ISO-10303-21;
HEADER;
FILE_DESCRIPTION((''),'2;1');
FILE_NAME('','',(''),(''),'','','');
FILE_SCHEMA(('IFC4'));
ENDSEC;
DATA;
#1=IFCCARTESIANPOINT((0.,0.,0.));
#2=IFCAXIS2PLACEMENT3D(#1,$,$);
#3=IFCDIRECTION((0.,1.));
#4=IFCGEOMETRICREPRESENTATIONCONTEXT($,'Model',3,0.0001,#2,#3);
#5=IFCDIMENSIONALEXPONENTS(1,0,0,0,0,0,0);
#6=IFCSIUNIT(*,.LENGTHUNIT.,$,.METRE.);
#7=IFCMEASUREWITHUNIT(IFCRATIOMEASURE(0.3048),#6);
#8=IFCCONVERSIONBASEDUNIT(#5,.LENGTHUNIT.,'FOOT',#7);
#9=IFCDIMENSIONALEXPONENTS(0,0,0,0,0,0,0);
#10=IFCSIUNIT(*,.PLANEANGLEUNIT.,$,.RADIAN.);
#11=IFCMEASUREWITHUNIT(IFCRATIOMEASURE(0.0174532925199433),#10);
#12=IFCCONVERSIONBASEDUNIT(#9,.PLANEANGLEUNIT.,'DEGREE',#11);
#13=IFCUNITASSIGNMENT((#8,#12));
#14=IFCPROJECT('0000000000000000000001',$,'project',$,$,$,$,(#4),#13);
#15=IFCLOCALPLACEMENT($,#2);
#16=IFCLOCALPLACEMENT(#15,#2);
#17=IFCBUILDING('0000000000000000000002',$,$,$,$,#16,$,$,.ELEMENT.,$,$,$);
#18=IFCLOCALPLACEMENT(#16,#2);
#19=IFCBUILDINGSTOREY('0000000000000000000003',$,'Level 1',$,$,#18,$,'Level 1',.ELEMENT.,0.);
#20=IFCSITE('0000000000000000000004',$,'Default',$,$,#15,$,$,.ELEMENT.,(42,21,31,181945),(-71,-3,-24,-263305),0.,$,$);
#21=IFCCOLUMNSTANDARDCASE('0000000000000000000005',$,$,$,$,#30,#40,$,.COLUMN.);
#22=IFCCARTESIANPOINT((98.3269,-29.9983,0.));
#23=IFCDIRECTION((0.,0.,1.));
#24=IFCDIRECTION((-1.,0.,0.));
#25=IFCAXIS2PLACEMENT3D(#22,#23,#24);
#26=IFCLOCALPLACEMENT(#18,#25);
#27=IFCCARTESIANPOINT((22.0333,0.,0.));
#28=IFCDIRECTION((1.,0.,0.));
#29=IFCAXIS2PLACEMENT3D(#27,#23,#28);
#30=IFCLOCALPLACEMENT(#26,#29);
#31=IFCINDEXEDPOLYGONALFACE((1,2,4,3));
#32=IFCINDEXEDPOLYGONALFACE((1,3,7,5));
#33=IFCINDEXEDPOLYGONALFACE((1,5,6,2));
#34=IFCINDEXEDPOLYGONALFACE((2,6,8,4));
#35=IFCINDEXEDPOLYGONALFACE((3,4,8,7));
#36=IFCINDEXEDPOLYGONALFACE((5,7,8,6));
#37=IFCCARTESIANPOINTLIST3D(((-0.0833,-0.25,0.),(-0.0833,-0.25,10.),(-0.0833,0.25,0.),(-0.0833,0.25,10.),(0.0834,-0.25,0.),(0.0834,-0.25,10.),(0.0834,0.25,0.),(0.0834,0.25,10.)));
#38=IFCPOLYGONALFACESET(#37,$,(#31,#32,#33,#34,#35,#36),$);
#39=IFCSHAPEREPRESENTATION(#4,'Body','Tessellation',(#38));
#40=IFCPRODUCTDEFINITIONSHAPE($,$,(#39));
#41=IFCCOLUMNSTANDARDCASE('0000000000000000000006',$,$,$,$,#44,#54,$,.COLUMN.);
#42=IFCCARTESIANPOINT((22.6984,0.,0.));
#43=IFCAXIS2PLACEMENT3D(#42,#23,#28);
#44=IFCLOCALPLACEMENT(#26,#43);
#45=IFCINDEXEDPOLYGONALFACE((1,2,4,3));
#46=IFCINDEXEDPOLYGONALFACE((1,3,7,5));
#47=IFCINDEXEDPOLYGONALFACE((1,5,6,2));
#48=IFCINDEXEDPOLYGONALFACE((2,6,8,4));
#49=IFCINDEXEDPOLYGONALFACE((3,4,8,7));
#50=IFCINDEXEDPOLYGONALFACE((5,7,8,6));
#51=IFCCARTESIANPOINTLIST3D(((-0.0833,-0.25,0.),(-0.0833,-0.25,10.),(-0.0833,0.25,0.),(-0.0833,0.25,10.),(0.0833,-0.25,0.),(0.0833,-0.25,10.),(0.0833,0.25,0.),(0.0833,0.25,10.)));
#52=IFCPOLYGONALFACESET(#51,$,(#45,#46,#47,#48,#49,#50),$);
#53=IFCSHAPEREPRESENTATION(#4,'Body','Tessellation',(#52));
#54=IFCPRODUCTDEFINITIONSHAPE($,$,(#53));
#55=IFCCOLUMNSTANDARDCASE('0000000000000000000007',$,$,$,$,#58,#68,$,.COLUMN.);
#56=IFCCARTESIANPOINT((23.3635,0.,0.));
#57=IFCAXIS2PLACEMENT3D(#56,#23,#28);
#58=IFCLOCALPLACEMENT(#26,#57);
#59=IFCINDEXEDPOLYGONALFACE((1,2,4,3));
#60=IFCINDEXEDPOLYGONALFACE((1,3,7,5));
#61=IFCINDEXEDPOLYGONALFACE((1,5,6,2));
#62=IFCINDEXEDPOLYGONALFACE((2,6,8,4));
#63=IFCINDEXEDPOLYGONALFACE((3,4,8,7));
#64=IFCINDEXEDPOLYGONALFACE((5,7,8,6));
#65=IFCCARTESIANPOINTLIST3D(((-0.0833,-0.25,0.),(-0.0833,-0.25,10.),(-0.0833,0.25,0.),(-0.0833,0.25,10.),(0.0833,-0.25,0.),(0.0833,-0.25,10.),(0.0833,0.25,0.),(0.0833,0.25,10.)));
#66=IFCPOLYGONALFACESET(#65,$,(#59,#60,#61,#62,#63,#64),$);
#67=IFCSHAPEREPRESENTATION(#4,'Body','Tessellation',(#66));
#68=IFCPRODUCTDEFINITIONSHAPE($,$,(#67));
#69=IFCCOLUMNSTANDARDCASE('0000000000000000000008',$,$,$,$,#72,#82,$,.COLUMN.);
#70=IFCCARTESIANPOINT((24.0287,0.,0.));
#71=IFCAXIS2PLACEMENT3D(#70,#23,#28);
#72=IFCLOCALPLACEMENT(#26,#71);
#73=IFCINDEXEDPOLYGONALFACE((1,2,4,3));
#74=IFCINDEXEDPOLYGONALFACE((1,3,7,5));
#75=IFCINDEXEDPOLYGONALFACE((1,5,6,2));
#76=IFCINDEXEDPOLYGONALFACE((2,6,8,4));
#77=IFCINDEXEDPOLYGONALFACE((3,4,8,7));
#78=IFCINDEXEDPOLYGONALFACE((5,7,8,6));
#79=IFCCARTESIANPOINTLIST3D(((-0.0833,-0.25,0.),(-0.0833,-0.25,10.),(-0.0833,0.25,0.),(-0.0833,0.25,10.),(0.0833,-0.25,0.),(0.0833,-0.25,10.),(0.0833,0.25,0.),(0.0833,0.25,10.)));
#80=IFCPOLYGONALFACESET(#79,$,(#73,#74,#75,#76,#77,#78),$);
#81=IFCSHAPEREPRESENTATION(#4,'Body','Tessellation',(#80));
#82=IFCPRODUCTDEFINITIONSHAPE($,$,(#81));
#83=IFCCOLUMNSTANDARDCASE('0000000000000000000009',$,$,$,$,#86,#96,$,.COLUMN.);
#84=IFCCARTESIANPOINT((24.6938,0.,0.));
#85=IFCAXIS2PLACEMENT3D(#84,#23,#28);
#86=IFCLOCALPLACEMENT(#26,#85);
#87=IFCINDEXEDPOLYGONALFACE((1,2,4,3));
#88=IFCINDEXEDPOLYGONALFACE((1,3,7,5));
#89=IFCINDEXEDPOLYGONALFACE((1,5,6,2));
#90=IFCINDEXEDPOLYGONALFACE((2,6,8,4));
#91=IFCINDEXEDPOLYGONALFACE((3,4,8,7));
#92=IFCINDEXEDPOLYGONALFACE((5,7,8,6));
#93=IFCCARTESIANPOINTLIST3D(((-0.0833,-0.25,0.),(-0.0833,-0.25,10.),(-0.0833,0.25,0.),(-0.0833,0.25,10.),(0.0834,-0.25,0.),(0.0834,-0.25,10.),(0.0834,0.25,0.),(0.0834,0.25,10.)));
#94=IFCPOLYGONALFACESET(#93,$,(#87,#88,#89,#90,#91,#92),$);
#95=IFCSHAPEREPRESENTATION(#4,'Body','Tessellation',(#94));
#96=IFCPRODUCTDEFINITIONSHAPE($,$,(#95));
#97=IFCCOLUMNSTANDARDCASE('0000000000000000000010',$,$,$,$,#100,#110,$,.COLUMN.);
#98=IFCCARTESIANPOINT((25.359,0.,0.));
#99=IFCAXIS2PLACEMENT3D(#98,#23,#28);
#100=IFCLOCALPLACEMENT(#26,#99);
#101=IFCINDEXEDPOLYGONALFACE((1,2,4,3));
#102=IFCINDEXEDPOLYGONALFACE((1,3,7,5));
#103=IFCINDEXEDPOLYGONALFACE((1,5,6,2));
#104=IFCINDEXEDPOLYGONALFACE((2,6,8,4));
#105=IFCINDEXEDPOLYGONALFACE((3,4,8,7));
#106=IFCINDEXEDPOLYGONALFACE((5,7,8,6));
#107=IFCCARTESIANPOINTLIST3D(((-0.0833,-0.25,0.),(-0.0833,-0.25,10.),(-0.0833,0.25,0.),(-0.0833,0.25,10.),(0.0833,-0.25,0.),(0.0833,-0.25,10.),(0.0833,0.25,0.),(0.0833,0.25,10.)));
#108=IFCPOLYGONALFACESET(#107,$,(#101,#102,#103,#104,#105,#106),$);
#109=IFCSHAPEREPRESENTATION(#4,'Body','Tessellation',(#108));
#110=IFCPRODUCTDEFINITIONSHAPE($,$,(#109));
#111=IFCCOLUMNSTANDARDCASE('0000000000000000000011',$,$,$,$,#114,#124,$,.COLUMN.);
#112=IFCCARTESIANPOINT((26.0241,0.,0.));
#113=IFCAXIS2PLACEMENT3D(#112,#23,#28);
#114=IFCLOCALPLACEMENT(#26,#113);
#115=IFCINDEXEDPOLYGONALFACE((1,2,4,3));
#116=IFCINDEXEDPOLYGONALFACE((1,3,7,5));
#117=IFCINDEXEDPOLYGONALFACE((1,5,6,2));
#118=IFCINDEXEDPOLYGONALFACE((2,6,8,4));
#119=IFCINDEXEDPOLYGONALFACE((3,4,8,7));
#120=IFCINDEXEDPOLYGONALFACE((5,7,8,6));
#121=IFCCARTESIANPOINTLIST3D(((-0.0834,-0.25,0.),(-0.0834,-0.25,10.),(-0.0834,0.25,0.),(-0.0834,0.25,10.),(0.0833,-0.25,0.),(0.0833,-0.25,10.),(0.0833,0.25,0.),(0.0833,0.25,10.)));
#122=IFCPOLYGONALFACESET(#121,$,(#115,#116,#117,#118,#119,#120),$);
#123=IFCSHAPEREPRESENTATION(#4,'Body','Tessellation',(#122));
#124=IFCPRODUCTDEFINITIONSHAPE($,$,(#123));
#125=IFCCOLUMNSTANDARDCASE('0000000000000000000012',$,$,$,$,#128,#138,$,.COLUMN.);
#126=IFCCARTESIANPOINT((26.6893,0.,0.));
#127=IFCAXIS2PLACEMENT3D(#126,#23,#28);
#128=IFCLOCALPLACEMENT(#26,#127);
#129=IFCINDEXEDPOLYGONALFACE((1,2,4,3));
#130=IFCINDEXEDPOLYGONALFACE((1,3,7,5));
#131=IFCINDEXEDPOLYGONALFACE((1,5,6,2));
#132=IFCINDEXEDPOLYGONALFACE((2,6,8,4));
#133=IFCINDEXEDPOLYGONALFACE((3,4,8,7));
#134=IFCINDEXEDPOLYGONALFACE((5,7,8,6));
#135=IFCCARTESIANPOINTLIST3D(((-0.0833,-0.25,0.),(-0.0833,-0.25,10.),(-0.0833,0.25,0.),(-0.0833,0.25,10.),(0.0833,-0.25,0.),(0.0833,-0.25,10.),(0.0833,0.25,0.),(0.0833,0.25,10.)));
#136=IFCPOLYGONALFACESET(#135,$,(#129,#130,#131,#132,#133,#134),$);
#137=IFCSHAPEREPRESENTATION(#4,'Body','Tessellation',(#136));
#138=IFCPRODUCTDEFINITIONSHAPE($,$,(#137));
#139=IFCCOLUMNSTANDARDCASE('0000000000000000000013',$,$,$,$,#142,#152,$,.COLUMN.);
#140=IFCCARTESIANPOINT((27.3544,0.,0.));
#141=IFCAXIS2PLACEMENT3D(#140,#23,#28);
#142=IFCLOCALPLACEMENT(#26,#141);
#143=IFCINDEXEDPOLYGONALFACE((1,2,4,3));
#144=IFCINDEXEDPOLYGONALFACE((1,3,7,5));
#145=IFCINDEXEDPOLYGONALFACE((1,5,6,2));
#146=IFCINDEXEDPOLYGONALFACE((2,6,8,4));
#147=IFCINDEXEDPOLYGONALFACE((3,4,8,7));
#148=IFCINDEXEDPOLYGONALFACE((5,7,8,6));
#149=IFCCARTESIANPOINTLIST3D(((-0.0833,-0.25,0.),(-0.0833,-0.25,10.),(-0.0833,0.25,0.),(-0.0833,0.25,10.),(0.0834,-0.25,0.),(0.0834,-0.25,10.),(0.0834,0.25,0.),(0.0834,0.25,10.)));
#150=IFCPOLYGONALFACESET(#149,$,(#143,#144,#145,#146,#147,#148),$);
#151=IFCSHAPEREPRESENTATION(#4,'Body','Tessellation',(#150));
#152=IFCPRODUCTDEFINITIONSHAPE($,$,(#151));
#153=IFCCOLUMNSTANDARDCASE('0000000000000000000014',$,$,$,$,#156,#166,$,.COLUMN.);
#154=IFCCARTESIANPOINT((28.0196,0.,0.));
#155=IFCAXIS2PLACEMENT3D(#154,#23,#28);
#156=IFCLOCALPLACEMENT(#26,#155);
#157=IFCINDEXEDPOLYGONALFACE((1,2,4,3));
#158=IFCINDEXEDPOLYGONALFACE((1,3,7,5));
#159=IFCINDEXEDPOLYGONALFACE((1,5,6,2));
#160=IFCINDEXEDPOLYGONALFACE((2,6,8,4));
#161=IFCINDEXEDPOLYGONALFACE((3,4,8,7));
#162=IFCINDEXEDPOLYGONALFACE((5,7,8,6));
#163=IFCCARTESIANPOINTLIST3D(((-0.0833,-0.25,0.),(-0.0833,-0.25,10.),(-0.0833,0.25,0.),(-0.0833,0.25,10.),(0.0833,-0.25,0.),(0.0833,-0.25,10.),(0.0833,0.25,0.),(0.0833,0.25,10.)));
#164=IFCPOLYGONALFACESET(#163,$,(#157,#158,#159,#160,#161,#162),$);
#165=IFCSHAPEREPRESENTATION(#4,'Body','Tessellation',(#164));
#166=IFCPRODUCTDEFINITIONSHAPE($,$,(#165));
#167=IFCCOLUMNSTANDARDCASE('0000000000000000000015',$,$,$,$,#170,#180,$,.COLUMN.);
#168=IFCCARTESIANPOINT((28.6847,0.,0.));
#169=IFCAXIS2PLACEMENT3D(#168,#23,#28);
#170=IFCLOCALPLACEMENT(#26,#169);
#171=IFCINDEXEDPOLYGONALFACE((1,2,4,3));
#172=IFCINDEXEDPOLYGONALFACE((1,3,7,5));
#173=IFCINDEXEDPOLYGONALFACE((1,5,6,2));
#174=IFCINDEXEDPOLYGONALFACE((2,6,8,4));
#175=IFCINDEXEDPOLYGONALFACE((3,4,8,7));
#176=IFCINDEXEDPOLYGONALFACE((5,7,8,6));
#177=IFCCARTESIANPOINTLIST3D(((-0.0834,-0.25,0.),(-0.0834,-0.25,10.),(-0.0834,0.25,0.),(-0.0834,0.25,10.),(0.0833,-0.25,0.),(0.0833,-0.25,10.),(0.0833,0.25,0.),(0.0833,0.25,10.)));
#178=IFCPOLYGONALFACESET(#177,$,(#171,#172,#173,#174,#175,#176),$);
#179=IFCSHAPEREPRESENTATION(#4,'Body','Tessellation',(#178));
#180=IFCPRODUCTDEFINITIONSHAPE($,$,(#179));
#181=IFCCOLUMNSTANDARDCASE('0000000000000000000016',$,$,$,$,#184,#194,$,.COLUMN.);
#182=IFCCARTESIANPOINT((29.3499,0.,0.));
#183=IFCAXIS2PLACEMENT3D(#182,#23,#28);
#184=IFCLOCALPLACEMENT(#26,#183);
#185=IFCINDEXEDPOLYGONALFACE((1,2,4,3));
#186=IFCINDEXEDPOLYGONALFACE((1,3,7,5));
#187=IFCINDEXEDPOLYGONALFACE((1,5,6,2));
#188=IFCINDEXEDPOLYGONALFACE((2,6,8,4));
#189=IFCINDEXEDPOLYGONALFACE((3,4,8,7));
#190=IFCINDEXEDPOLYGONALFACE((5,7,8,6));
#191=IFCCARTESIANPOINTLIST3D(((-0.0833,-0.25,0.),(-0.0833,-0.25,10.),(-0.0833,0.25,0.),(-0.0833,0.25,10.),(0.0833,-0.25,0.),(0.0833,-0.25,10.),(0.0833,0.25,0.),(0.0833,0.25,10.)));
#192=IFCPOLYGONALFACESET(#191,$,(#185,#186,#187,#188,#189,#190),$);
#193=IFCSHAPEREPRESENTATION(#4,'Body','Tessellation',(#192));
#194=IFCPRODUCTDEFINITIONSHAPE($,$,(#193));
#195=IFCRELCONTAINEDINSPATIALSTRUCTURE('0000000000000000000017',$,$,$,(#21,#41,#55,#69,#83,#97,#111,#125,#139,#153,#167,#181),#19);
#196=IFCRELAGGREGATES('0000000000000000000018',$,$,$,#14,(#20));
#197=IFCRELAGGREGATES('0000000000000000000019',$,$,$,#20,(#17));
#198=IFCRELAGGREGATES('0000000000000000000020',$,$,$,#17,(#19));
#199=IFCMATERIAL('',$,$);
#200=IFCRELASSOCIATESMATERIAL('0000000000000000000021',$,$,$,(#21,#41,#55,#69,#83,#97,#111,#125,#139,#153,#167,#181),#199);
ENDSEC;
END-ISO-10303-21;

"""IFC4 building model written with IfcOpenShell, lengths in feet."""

from ifc_helpers import new_model, entity, si_unit, converted_unit, direction, frame, origin, place, context, project, spatial, rectangle, extrude, material, element, save


model = new_model("IFC4")

# Units and contexts
model_context = context("Model", 3, precision=0.0001, world=origin(), true_north=direction((0.0, 1.0)))
ifc_project = project(units=[converted_unit("LENGTHUNIT", "FOOT", entity("IfcRatioMeasure", 0.3048), si_unit("LENGTHUNIT", "METRE"), dimensions=[1, 0, 0, 0, 0, 0, 0]), converted_unit("PLANEANGLEUNIT", "DEGREE", entity("IfcRatioMeasure", 0.0174532925199433), si_unit("PLANEANGLEUNIT", "RADIAN"), dimensions=[0, 0, 0, 0, 0, 0, 0])], contexts=[model_context])

# Site, building, storey
site_placement = place(None, origin())
site = spatial("IfcSite", under=ifc_project, at=site_placement, Name="Default", CompositionType="ELEMENT", RefLatitude=(42, 21, 31, 181945), RefLongitude=(-71, -3, -24, -263305), RefElevation=0.0)
building_placement = place(site_placement, origin())
building = spatial("IfcBuilding", under=site, at=building_placement, CompositionType="ELEMENT")
storey_placement = place(building_placement, origin())
storey = spatial("IfcBuildingStorey", under=building, at=storey_placement, Name="Level 1", LongName="Level 1", CompositionType="ELEMENT", Elevation=0.0)

# Columns
ifc_material = material(Name="")
placement = place(storey_placement, frame((98.3269, -29.9983, 0.0), z_axis=(0.0, 0.0, 1.0), x_axis=(-1.0, 0.0, 0.0)))
for number, where, z_axis, x_axis in (
    (1, (22.0333, 0.0, 0.0), (0.0, 0.0, 1.0), (1.0, 0.0, 0.0)),
    (2, (22.6984, 0.0, 0.0), (0.0, 0.0, 1.0), (1.0, 0.0, 0.0)),
    (3, (23.3635, 0.0, 0.0), (0.0, 0.0, 1.0), (1.0, 0.0, 0.0)),
    (4, (24.0287, 0.0, 0.0), (0.0, 0.0, 1.0), (1.0, 0.0, 0.0)),
    (5, (24.6938, 0.0, 0.0), (0.0, 0.0, 1.0), (1.0, 0.0, 0.0)),
    (6, (25.359, 0.0, 0.0), (0.0, 0.0, 1.0), (1.0, 0.0, 0.0)),
    (7, (26.0241, 0.0, 0.0), (0.0, 0.0, 1.0), (1.0, 0.0, 0.0)),
    (8, (26.6893, 0.0, 0.0), (0.0, 0.0, 1.0), (1.0, 0.0, 0.0)),
    (9, (27.3544, 0.0, 0.0), (0.0, 0.0, 1.0), (1.0, 0.0, 0.0)),
    (10, (28.0196, 0.0, 0.0), (0.0, 0.0, 1.0), (1.0, 0.0, 0.0)),
    (11, (28.6847, 0.0, 0.0), (0.0, 0.0, 1.0), (1.0, 0.0, 0.0)),
    (12, (29.3499, 0.0, 0.0), (0.0, 0.0, 1.0), (1.0, 0.0, 0.0)),
):
    element("IfcColumnStandardCase", number, at=place(placement, frame(where, z_axis=z_axis, x_axis=x_axis)), inside=storey, material=ifc_material, PredefinedType="COLUMN", context=model_context, shape_type="SweptSolid", body=[
        extrude(rectangle(XDim=0.1667, YDim=0.5), origin(), (0.0, 0.0, 1.0), 10.0),
    ])

save(model, "model.ifc")
